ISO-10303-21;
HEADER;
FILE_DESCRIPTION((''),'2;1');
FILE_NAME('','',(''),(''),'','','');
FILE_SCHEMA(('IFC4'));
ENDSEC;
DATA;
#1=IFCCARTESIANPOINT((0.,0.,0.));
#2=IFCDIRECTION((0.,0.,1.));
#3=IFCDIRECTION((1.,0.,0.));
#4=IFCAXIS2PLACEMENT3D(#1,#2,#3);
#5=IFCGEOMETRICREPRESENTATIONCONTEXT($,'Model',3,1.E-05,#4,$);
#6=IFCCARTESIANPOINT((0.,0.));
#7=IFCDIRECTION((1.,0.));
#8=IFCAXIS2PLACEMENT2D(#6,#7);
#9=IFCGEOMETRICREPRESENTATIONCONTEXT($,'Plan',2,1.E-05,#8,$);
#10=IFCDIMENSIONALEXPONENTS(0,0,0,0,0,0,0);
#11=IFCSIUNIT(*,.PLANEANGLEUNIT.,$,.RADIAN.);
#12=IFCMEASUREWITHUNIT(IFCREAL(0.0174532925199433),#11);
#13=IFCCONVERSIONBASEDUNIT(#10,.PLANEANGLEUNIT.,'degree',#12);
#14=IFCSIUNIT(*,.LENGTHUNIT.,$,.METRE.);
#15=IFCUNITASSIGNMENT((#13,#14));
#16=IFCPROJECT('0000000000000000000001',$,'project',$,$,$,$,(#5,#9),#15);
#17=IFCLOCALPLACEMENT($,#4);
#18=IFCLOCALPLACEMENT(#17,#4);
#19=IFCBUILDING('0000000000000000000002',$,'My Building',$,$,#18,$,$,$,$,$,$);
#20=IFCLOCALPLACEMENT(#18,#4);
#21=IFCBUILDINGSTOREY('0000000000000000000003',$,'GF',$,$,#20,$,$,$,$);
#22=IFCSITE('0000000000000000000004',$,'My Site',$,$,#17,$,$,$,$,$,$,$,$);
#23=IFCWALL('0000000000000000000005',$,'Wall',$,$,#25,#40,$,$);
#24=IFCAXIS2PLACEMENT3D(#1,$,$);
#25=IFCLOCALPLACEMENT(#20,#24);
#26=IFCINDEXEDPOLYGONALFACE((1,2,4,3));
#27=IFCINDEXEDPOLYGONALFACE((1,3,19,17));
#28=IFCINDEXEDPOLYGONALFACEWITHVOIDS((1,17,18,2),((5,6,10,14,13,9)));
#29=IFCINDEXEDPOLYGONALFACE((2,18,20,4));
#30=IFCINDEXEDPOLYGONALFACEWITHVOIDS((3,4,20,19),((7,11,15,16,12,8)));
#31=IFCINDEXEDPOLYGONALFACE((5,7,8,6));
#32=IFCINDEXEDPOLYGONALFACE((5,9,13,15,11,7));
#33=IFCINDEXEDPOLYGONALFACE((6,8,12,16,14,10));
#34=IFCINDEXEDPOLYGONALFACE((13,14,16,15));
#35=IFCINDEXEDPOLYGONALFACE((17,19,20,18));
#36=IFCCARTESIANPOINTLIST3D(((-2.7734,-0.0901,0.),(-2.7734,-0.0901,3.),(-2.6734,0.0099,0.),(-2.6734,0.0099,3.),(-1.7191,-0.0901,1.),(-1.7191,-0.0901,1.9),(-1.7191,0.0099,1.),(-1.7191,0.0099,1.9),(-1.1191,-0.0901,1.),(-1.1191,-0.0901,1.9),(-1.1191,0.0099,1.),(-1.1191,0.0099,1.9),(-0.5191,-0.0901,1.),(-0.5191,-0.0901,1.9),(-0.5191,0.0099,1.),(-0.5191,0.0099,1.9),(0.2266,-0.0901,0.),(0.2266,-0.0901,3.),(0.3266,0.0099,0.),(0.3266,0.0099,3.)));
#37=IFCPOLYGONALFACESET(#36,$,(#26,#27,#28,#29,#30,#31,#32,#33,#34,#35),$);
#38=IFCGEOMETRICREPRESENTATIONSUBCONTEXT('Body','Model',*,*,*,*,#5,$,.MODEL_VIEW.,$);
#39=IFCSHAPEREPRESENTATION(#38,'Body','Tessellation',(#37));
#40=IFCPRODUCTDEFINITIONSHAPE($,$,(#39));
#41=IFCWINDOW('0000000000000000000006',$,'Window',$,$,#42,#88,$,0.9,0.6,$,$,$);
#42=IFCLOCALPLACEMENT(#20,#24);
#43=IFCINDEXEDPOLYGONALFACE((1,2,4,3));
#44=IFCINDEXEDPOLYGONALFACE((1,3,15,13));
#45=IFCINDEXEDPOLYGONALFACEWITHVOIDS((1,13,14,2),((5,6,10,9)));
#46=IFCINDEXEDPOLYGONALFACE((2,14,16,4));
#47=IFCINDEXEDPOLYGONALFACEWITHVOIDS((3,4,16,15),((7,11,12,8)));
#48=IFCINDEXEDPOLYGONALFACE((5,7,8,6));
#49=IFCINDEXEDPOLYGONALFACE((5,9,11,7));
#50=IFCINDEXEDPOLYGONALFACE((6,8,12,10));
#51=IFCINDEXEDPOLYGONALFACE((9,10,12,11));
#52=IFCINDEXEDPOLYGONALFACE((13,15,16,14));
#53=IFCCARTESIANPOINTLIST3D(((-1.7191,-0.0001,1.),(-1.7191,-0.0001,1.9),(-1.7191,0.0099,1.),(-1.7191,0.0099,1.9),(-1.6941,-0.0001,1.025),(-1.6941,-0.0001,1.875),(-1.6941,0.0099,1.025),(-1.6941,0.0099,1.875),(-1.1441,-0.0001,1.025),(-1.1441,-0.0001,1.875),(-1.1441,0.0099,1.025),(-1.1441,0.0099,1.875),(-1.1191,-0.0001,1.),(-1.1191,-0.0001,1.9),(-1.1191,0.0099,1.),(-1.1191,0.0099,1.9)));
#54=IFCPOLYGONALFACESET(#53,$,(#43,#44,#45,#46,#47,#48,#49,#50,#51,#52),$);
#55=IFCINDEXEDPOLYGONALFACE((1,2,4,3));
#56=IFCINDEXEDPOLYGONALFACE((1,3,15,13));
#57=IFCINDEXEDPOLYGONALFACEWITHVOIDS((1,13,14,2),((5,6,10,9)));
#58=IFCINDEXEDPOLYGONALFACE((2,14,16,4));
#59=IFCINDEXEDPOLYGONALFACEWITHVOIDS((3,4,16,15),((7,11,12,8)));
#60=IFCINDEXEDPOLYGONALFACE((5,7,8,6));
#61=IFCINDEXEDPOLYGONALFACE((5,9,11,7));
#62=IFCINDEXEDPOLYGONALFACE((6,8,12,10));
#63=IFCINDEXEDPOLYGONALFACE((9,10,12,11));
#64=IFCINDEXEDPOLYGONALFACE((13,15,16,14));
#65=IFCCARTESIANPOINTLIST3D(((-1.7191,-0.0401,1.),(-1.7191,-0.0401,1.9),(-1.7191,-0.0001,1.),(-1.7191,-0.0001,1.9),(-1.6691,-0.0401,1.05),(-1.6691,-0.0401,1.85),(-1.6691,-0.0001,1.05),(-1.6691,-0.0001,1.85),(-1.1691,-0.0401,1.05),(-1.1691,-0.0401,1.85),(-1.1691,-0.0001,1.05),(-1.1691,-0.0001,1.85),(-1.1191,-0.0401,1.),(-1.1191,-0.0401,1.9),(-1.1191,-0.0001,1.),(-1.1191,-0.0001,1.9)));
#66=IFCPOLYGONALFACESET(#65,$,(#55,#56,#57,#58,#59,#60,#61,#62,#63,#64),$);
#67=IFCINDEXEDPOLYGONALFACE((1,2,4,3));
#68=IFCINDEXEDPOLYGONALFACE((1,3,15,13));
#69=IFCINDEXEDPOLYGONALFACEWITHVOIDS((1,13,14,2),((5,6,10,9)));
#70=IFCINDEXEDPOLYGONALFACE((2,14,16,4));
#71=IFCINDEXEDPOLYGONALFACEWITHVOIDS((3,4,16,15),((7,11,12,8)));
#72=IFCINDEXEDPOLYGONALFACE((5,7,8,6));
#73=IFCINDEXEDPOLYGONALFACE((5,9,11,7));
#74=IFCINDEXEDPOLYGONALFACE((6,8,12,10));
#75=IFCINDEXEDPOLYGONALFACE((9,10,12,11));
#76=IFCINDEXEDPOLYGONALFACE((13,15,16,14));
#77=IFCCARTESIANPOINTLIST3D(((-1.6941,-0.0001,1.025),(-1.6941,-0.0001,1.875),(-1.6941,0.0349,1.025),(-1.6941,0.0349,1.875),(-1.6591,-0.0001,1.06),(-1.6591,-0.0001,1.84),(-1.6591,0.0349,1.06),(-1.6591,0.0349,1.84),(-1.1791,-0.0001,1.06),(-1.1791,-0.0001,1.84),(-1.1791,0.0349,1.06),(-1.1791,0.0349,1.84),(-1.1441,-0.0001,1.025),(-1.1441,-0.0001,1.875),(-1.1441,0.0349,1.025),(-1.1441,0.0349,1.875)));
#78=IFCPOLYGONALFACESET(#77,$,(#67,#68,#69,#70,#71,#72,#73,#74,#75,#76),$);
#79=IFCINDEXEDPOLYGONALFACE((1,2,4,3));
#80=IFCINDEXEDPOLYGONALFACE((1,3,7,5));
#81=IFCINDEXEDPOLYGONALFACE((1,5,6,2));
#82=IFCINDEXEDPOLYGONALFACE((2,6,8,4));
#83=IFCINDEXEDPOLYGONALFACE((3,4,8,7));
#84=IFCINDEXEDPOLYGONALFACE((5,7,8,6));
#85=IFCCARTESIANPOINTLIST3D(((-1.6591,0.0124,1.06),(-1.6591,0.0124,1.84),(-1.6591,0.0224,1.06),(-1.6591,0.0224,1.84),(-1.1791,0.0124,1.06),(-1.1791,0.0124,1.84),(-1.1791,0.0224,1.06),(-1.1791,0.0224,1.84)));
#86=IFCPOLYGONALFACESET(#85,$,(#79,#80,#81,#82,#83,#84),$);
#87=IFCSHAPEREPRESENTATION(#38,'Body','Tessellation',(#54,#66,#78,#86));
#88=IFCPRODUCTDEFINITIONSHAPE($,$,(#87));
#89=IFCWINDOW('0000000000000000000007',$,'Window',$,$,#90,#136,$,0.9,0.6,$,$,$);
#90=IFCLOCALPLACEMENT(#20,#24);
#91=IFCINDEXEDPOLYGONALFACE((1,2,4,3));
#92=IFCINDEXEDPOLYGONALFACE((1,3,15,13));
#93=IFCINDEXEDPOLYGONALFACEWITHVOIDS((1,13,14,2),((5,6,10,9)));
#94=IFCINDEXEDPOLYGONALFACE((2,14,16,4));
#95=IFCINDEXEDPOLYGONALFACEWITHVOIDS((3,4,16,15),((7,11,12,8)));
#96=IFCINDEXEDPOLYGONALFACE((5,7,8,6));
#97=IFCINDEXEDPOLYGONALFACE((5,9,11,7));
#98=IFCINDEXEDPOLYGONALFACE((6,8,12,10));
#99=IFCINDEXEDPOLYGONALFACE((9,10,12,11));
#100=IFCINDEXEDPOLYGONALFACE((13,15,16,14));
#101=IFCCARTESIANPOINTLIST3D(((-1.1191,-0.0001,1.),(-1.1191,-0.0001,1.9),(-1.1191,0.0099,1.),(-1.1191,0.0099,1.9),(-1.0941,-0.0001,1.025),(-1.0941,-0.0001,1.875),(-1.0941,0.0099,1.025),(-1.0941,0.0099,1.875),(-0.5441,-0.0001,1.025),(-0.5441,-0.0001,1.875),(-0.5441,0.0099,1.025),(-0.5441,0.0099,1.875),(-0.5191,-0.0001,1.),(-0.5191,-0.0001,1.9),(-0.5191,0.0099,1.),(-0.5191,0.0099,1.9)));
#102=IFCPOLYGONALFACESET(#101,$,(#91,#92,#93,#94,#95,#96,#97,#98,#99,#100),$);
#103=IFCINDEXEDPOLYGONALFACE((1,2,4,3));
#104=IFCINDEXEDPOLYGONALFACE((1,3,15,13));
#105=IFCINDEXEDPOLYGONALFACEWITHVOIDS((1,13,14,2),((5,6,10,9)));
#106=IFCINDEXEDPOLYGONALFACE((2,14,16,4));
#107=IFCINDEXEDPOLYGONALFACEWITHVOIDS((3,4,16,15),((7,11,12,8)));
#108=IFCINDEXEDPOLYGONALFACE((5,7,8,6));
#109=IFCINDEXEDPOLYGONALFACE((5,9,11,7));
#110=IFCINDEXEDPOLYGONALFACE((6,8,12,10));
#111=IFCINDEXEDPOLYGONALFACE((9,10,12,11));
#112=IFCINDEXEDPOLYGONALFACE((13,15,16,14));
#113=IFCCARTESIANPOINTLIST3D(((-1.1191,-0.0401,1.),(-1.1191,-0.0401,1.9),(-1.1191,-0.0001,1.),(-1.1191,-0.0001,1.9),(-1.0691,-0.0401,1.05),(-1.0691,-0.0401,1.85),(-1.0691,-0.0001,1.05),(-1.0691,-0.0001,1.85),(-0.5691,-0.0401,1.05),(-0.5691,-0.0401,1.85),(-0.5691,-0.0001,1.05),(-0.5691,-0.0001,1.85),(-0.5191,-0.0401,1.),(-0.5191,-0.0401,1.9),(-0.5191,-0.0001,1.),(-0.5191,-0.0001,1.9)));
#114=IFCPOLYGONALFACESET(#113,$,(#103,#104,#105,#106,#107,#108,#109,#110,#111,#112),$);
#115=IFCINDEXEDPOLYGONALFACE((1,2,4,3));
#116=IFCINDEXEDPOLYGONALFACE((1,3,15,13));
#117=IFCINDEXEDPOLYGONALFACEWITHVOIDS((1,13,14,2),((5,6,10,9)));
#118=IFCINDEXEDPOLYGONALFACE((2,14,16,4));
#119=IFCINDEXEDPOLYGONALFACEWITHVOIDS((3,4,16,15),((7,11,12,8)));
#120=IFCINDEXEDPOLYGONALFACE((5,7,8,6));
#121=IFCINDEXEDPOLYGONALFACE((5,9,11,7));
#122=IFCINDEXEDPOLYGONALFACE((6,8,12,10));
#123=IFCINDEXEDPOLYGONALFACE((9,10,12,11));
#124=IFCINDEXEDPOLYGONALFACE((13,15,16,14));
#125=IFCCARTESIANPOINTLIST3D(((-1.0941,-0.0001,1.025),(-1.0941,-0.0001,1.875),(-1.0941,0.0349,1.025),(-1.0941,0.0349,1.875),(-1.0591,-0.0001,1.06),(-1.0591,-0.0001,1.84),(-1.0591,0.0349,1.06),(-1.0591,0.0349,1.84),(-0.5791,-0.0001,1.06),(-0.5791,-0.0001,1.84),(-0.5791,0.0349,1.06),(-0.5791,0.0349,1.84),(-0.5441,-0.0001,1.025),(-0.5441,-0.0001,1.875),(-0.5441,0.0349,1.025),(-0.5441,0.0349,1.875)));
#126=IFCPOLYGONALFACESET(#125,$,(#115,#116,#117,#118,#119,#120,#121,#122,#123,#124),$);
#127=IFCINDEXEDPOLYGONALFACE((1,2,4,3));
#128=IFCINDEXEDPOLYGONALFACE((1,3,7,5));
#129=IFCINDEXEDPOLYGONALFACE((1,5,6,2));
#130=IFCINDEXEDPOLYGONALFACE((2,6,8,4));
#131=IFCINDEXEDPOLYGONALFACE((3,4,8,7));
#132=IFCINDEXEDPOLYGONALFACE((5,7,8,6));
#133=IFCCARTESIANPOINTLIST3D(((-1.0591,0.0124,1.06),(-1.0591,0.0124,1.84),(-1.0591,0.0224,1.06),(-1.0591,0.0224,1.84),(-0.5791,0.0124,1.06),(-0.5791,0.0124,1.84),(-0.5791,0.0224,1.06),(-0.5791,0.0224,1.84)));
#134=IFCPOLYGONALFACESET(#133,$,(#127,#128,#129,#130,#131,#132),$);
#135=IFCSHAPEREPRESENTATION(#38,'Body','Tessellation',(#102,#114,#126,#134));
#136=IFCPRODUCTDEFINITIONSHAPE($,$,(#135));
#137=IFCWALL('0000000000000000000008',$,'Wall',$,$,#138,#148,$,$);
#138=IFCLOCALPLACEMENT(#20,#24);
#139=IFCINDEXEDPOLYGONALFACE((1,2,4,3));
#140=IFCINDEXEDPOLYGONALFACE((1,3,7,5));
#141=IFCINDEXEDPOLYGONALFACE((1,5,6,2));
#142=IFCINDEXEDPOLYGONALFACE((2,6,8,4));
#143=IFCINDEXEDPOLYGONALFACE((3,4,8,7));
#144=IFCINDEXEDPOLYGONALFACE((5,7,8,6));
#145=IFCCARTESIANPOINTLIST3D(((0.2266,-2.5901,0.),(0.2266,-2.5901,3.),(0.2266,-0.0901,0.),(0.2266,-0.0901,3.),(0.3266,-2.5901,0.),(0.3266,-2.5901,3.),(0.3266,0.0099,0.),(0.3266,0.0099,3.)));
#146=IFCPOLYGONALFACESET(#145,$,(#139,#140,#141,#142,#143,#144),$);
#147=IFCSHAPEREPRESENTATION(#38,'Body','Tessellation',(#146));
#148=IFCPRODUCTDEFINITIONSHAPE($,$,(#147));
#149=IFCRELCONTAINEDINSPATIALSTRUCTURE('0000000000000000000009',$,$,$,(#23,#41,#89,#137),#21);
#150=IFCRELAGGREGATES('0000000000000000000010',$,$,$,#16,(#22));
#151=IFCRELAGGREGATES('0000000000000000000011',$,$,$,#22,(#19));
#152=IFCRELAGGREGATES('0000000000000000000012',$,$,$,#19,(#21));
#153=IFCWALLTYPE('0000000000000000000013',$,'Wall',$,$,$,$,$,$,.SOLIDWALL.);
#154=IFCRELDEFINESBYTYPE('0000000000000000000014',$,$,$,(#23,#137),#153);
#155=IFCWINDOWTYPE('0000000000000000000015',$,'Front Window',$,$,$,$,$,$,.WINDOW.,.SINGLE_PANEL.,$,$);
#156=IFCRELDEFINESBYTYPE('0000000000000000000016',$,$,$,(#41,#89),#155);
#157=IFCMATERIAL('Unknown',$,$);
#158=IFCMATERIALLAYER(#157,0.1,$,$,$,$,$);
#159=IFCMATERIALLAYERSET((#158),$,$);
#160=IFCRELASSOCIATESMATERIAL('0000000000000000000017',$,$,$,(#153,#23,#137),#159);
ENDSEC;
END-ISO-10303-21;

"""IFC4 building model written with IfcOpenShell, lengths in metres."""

from ifc_helpers import new_model, entity, si_unit, converted_unit, frame, origin_with_axes, origin_2d_with_axis, place, context, subcontext, project, spatial, line, indexed_curve, outline, extrude, shape, source, transform, mapped, material, layer, layer_set, layer_usage, type_object, type_shapes, element, fill, save


model = new_model("IFC4")

# Units and contexts
model_context = context("Model", 3, precision=1e-05, world=origin_with_axes())
plan_context = context("Plan", 2, precision=1e-05, world=origin_2d_with_axis())
body_context_1 = subcontext(model_context, "Body", "Model", "MODEL_VIEW")
body_context_2 = subcontext(plan_context, "Body", "Plan", "PLAN_VIEW")
ifc_project = project(units=[converted_unit("PLANEANGLEUNIT", "degree", entity("IfcReal", 0.0174532925199433), si_unit("PLANEANGLEUNIT", "RADIAN"), dimensions=[0, 0, 0, 0, 0, 0, 0]), si_unit("LENGTHUNIT", "METRE")], contexts=[model_context, plan_context])

# Site, building, storey
site_placement = place(None, origin_with_axes())
site = spatial("IfcSite", under=ifc_project, at=site_placement, Name="My Site")
building_placement = place(site_placement, origin_with_axes())
building = spatial("IfcBuilding", under=site, at=building_placement, Name="My Building")
storey_placement = place(building_placement, origin_with_axes())
storey = spatial("IfcBuildingStorey", under=building, at=storey_placement, Name="GF")

# Shared definitions
ifc_material = material(Name="Unknown")

# Shared definitions
ifc_layer_1 = layer(ifc_material, 0.1)
ifc_layer_set_1 = layer_set([ifc_layer_1])
wall_type = type_object("IfcWallType", Name="Wall", PredefinedType="SOLIDWALL", material=ifc_layer_set_1)
shared_shape_1 = source(origin_with_axes(), body_context_1, "Body", "SweptSolid", [
    extrude(outline(indexed_curve([(0.0, 0.0), (0.6, 0.0), (0.6, 0.9), (0.0, 0.9)], segments=[line(1, 2, 3, 4, 1)])), frame((0.0, -0.6, 0.0), z_axis=(0.0, -1.0, 0.0), x_axis=(1.0, 0.0, 0.0)), (0.0, 0.0, -1.0), 1.2),
])
window_type_1 = type_object("IfcWindowType", Name="Front Window", PartitioningType="SINGLE_PANEL", PredefinedType="WINDOW")
shared_shape_2 = source(origin_with_axes(), body_context_1, "Body", "SweptSolid", [
    extrude(outline(indexed_curve([(0.0, 0.0), (0.6, 0.0), (0.6, 0.9), (0.0, 0.9)], segments=[line(1, 2, 3, 4, 1)]), holes=[indexed_curve([(0.025, 0.025), (0.575, 0.025), (0.575, 0.875), (0.025, 0.875)], segments=[line(1, 2, 3, 4, 1)])]), frame((0.0, 0.09, 0.0), z_axis=(0.0, -1.0, 0.0), x_axis=(1.0, 0.0, 0.0)), (0.0, 0.0, -1.0), 0.01),
    extrude(outline(indexed_curve([(0.0, 0.0), (0.6, 0.0), (0.6, 0.9), (0.0, 0.9)], segments=[line(1, 2, 3, 4, 1)]), holes=[indexed_curve([(0.05, 0.05), (0.55, 0.05), (0.55, 0.85), (0.05, 0.85)], segments=[line(1, 2, 3, 4, 1)])]), frame((0.0, 0.05, 0.0), z_axis=(0.0, -1.0, 0.0), x_axis=(1.0, 0.0, 0.0)), (0.0, 0.0, -1.0), 0.04),
    extrude(outline(indexed_curve([(0.0, 0.0), (0.55, 0.0), (0.55, 0.85), (0.0, 0.85)], segments=[line(1, 2, 3, 4, 1)]), holes=[indexed_curve([(0.035, 0.035), (0.515, 0.035), (0.515, 0.815), (0.035, 0.815)], segments=[line(1, 2, 3, 4, 1)])]), frame((0.025, 0.09, 0.025), z_axis=(0.0, -1.0, 0.0), x_axis=(1.0, 0.0, 0.0)), (0.0, 0.0, -1.0), 0.035),
    extrude(outline(indexed_curve([(0.035, 0.035), (0.515, 0.035), (0.515, 0.815), (0.035, 0.815)], segments=[line(1, 2, 3, 4, 1)])), frame((0.025, 0.1025, 0.025), z_axis=(0.0, -1.0, 0.0), x_axis=(1.0, 0.0, 0.0)), (0.0, 0.0, -1.0), 0.01),
])
shared_shape_3 = source(origin_with_axes(), body_context_2, "Body", "Curve2D", [
    entity("IfcIndexedPolyCurve", entity("IfcCartesianPointList2D", [[0.05, 0.05], [0.55, 0.05]])),
    entity("IfcIndexedPolyCurve", entity("IfcCartesianPointList2D", [[0.0, 0.1], [0.025, 0.1], [0.025, 0.09], [0.05, 0.09], [0.05, 0.05], [0.0, 0.05]]), [entity("IfcLineIndex", [1, 2, 3, 4, 5, 6, 1])]),
    entity("IfcIndexedPolyCurve", entity("IfcCartesianPointList2D", [[0.6, 0.1], [0.575, 0.1], [0.575, 0.09], [0.55, 0.09], [0.55, 0.05], [0.6, 0.05]]), [entity("IfcLineIndex", [1, 2, 3, 4, 5, 6, 1])]),
    entity("IfcIndexedPolyCurve", entity("IfcCartesianPointList2D", [[0.025, 0.09], [0.06, 0.09], [0.06, 0.125], [0.025, 0.125]]), [entity("IfcLineIndex", [1, 2, 3, 4, 1])]),
    entity("IfcIndexedPolyCurve", entity("IfcCartesianPointList2D", [[0.575, 0.09], [0.54, 0.09], [0.54, 0.125], [0.575, 0.125]]), [entity("IfcLineIndex", [1, 2, 3, 4, 1])]),
    entity("IfcIndexedPolyCurve", entity("IfcCartesianPointList2D", [[0.06, 0.09], [0.54, 0.09]])),
    entity("IfcIndexedPolyCurve", entity("IfcCartesianPointList2D", [[0.06, 0.125], [0.54, 0.125]])),
    entity("IfcIndexedPolyCurve", entity("IfcCartesianPointList2D", [[0.06, 0.1075], [0.54, 0.1075]])),
])
type_shapes(window_type_1, [shared_shape_2, shared_shape_3])

# Wall, openings, windows
ifc_layer_usage_1 = layer_usage(ifc_layer_set_1, "AXIS2", "POSITIVE", 0.0)
wall_1_placement = place(storey_placement, frame((-2.7734, -0.0901, 0.0), z_axis=(0.0, 0.0, 1.0), x_axis=(1.0, 0.0, 0.0)))
wall_1 = element("IfcWall", 1, at=wall_1_placement, inside=storey, type_object=wall_type, material=ifc_layer_usage_1, Name="Wall", context=body_context_1, shape_type="SweptSolid", body=[
    extrude(outline(indexed_curve([(0.0, 0.0), (0.1, 0.1), (3.1, 0.1), (3.0, 0.0)], segments=[line(1, 2, 3, 4, 1)])), origin_with_axes(), (0.0, 0.0, 1.0), 3.0),
])
opening_1_placement = place(wall_1_placement, frame((1.0543, 0.0, 1.0), z_axis=(0.0, 0.0, 1.0), x_axis=(1.0, 0.0, 0.0)))
opening_1 = element("IfcOpeningElement", 2, at=opening_1_placement, cuts=wall_1, PredefinedType="OPENING", context=body_context_1, shape_type="MappedRepresentation", body=[
    mapped(shared_shape_1, transform((0.0, 0.0, 0.0), x_axis=(1.0, 0.0, 0.0), y_axis=(0.0, 1.0, 0.0), z_axis=(0.0, 0.0, 1.0), scale=1.0)),
])
opening_2_placement = place(wall_1_placement, frame((1.6543, 0.0, 1.0), z_axis=(0.0, 0.0, 1.0), x_axis=(1.0, 0.0, 0.0)))
opening_2 = element("IfcOpeningElement", 3, at=opening_2_placement, cuts=wall_1, PredefinedType="OPENING", context=body_context_1, shape_type="MappedRepresentation", body=[
    mapped(shared_shape_1, transform((0.0, 0.0, 0.0), x_axis=(1.0, 0.0, 0.0), y_axis=(0.0, 1.0, 0.0), z_axis=(0.0, 0.0, 1.0), scale=1.0)),
])
window_1_placement = place(opening_1_placement, origin_with_axes())
window_1 = element("IfcWindow", 4, at=window_1_placement, inside=storey, type_object=window_type_1, Name="Window", OverallHeight=0.9, OverallWidth=0.6, shapes=[
    shape(body_context_1, "Body", "MappedRepresentation", [mapped(shared_shape_2, transform((0.0, 0.0, 0.0), x_axis=(1.0, 0.0, 0.0), y_axis=(0.0, 1.0, 0.0), z_axis=(0.0, 0.0, 1.0), scale=1.0))]),
    shape(body_context_2, "Body", "MappedRepresentation", [mapped(shared_shape_3, transform((0.0, 0.0, 0.0), x_axis=(1.0, 0.0, 0.0), y_axis=(0.0, 1.0, 0.0), z_axis=(0.0, 0.0, 1.0), scale=1.0))]),
])
fill(opening_1, window_1)
window_2_placement = place(opening_2_placement, origin_with_axes())
window_2 = element("IfcWindow", 5, at=window_2_placement, inside=storey, type_object=window_type_1, Name="Window", OverallHeight=0.9, OverallWidth=0.6, shapes=[
    shape(body_context_1, "Body", "MappedRepresentation", [mapped(shared_shape_2, transform((0.0, 0.0, 0.0), x_axis=(1.0, 0.0, 0.0), y_axis=(0.0, 1.0, 0.0), z_axis=(0.0, 0.0, 1.0), scale=1.0))]),
    shape(body_context_2, "Body", "MappedRepresentation", [mapped(shared_shape_3, transform((0.0, 0.0, 0.0), x_axis=(1.0, 0.0, 0.0), y_axis=(0.0, 1.0, 0.0), z_axis=(0.0, 0.0, 1.0), scale=1.0))]),
])
fill(opening_2, window_2)

# Wall
ifc_layer_usage_2 = layer_usage(ifc_layer_set_1, "AXIS2", "POSITIVE", 0.0)
wall_2_placement = place(storey_placement, frame((0.2266, -0.0901, 0.0), z_axis=(0.0, 0.0, 1.0), x_axis=(0.0, -1.0, 0.0)))
element("IfcWall", 6, at=wall_2_placement, inside=storey, type_object=wall_type, material=ifc_layer_usage_2, Name="Wall", context=body_context_1, shape_type="SweptSolid", body=[
    extrude(outline(indexed_curve([(0.0, 0.0), (-0.1, 0.1), (2.5, 0.1), (2.5, 0.0)], segments=[line(1, 2, 3, 4, 1)])), origin_with_axes(), (0.0, 0.0, 1.0), 3.0),
])

save(model, "model.ifc")
